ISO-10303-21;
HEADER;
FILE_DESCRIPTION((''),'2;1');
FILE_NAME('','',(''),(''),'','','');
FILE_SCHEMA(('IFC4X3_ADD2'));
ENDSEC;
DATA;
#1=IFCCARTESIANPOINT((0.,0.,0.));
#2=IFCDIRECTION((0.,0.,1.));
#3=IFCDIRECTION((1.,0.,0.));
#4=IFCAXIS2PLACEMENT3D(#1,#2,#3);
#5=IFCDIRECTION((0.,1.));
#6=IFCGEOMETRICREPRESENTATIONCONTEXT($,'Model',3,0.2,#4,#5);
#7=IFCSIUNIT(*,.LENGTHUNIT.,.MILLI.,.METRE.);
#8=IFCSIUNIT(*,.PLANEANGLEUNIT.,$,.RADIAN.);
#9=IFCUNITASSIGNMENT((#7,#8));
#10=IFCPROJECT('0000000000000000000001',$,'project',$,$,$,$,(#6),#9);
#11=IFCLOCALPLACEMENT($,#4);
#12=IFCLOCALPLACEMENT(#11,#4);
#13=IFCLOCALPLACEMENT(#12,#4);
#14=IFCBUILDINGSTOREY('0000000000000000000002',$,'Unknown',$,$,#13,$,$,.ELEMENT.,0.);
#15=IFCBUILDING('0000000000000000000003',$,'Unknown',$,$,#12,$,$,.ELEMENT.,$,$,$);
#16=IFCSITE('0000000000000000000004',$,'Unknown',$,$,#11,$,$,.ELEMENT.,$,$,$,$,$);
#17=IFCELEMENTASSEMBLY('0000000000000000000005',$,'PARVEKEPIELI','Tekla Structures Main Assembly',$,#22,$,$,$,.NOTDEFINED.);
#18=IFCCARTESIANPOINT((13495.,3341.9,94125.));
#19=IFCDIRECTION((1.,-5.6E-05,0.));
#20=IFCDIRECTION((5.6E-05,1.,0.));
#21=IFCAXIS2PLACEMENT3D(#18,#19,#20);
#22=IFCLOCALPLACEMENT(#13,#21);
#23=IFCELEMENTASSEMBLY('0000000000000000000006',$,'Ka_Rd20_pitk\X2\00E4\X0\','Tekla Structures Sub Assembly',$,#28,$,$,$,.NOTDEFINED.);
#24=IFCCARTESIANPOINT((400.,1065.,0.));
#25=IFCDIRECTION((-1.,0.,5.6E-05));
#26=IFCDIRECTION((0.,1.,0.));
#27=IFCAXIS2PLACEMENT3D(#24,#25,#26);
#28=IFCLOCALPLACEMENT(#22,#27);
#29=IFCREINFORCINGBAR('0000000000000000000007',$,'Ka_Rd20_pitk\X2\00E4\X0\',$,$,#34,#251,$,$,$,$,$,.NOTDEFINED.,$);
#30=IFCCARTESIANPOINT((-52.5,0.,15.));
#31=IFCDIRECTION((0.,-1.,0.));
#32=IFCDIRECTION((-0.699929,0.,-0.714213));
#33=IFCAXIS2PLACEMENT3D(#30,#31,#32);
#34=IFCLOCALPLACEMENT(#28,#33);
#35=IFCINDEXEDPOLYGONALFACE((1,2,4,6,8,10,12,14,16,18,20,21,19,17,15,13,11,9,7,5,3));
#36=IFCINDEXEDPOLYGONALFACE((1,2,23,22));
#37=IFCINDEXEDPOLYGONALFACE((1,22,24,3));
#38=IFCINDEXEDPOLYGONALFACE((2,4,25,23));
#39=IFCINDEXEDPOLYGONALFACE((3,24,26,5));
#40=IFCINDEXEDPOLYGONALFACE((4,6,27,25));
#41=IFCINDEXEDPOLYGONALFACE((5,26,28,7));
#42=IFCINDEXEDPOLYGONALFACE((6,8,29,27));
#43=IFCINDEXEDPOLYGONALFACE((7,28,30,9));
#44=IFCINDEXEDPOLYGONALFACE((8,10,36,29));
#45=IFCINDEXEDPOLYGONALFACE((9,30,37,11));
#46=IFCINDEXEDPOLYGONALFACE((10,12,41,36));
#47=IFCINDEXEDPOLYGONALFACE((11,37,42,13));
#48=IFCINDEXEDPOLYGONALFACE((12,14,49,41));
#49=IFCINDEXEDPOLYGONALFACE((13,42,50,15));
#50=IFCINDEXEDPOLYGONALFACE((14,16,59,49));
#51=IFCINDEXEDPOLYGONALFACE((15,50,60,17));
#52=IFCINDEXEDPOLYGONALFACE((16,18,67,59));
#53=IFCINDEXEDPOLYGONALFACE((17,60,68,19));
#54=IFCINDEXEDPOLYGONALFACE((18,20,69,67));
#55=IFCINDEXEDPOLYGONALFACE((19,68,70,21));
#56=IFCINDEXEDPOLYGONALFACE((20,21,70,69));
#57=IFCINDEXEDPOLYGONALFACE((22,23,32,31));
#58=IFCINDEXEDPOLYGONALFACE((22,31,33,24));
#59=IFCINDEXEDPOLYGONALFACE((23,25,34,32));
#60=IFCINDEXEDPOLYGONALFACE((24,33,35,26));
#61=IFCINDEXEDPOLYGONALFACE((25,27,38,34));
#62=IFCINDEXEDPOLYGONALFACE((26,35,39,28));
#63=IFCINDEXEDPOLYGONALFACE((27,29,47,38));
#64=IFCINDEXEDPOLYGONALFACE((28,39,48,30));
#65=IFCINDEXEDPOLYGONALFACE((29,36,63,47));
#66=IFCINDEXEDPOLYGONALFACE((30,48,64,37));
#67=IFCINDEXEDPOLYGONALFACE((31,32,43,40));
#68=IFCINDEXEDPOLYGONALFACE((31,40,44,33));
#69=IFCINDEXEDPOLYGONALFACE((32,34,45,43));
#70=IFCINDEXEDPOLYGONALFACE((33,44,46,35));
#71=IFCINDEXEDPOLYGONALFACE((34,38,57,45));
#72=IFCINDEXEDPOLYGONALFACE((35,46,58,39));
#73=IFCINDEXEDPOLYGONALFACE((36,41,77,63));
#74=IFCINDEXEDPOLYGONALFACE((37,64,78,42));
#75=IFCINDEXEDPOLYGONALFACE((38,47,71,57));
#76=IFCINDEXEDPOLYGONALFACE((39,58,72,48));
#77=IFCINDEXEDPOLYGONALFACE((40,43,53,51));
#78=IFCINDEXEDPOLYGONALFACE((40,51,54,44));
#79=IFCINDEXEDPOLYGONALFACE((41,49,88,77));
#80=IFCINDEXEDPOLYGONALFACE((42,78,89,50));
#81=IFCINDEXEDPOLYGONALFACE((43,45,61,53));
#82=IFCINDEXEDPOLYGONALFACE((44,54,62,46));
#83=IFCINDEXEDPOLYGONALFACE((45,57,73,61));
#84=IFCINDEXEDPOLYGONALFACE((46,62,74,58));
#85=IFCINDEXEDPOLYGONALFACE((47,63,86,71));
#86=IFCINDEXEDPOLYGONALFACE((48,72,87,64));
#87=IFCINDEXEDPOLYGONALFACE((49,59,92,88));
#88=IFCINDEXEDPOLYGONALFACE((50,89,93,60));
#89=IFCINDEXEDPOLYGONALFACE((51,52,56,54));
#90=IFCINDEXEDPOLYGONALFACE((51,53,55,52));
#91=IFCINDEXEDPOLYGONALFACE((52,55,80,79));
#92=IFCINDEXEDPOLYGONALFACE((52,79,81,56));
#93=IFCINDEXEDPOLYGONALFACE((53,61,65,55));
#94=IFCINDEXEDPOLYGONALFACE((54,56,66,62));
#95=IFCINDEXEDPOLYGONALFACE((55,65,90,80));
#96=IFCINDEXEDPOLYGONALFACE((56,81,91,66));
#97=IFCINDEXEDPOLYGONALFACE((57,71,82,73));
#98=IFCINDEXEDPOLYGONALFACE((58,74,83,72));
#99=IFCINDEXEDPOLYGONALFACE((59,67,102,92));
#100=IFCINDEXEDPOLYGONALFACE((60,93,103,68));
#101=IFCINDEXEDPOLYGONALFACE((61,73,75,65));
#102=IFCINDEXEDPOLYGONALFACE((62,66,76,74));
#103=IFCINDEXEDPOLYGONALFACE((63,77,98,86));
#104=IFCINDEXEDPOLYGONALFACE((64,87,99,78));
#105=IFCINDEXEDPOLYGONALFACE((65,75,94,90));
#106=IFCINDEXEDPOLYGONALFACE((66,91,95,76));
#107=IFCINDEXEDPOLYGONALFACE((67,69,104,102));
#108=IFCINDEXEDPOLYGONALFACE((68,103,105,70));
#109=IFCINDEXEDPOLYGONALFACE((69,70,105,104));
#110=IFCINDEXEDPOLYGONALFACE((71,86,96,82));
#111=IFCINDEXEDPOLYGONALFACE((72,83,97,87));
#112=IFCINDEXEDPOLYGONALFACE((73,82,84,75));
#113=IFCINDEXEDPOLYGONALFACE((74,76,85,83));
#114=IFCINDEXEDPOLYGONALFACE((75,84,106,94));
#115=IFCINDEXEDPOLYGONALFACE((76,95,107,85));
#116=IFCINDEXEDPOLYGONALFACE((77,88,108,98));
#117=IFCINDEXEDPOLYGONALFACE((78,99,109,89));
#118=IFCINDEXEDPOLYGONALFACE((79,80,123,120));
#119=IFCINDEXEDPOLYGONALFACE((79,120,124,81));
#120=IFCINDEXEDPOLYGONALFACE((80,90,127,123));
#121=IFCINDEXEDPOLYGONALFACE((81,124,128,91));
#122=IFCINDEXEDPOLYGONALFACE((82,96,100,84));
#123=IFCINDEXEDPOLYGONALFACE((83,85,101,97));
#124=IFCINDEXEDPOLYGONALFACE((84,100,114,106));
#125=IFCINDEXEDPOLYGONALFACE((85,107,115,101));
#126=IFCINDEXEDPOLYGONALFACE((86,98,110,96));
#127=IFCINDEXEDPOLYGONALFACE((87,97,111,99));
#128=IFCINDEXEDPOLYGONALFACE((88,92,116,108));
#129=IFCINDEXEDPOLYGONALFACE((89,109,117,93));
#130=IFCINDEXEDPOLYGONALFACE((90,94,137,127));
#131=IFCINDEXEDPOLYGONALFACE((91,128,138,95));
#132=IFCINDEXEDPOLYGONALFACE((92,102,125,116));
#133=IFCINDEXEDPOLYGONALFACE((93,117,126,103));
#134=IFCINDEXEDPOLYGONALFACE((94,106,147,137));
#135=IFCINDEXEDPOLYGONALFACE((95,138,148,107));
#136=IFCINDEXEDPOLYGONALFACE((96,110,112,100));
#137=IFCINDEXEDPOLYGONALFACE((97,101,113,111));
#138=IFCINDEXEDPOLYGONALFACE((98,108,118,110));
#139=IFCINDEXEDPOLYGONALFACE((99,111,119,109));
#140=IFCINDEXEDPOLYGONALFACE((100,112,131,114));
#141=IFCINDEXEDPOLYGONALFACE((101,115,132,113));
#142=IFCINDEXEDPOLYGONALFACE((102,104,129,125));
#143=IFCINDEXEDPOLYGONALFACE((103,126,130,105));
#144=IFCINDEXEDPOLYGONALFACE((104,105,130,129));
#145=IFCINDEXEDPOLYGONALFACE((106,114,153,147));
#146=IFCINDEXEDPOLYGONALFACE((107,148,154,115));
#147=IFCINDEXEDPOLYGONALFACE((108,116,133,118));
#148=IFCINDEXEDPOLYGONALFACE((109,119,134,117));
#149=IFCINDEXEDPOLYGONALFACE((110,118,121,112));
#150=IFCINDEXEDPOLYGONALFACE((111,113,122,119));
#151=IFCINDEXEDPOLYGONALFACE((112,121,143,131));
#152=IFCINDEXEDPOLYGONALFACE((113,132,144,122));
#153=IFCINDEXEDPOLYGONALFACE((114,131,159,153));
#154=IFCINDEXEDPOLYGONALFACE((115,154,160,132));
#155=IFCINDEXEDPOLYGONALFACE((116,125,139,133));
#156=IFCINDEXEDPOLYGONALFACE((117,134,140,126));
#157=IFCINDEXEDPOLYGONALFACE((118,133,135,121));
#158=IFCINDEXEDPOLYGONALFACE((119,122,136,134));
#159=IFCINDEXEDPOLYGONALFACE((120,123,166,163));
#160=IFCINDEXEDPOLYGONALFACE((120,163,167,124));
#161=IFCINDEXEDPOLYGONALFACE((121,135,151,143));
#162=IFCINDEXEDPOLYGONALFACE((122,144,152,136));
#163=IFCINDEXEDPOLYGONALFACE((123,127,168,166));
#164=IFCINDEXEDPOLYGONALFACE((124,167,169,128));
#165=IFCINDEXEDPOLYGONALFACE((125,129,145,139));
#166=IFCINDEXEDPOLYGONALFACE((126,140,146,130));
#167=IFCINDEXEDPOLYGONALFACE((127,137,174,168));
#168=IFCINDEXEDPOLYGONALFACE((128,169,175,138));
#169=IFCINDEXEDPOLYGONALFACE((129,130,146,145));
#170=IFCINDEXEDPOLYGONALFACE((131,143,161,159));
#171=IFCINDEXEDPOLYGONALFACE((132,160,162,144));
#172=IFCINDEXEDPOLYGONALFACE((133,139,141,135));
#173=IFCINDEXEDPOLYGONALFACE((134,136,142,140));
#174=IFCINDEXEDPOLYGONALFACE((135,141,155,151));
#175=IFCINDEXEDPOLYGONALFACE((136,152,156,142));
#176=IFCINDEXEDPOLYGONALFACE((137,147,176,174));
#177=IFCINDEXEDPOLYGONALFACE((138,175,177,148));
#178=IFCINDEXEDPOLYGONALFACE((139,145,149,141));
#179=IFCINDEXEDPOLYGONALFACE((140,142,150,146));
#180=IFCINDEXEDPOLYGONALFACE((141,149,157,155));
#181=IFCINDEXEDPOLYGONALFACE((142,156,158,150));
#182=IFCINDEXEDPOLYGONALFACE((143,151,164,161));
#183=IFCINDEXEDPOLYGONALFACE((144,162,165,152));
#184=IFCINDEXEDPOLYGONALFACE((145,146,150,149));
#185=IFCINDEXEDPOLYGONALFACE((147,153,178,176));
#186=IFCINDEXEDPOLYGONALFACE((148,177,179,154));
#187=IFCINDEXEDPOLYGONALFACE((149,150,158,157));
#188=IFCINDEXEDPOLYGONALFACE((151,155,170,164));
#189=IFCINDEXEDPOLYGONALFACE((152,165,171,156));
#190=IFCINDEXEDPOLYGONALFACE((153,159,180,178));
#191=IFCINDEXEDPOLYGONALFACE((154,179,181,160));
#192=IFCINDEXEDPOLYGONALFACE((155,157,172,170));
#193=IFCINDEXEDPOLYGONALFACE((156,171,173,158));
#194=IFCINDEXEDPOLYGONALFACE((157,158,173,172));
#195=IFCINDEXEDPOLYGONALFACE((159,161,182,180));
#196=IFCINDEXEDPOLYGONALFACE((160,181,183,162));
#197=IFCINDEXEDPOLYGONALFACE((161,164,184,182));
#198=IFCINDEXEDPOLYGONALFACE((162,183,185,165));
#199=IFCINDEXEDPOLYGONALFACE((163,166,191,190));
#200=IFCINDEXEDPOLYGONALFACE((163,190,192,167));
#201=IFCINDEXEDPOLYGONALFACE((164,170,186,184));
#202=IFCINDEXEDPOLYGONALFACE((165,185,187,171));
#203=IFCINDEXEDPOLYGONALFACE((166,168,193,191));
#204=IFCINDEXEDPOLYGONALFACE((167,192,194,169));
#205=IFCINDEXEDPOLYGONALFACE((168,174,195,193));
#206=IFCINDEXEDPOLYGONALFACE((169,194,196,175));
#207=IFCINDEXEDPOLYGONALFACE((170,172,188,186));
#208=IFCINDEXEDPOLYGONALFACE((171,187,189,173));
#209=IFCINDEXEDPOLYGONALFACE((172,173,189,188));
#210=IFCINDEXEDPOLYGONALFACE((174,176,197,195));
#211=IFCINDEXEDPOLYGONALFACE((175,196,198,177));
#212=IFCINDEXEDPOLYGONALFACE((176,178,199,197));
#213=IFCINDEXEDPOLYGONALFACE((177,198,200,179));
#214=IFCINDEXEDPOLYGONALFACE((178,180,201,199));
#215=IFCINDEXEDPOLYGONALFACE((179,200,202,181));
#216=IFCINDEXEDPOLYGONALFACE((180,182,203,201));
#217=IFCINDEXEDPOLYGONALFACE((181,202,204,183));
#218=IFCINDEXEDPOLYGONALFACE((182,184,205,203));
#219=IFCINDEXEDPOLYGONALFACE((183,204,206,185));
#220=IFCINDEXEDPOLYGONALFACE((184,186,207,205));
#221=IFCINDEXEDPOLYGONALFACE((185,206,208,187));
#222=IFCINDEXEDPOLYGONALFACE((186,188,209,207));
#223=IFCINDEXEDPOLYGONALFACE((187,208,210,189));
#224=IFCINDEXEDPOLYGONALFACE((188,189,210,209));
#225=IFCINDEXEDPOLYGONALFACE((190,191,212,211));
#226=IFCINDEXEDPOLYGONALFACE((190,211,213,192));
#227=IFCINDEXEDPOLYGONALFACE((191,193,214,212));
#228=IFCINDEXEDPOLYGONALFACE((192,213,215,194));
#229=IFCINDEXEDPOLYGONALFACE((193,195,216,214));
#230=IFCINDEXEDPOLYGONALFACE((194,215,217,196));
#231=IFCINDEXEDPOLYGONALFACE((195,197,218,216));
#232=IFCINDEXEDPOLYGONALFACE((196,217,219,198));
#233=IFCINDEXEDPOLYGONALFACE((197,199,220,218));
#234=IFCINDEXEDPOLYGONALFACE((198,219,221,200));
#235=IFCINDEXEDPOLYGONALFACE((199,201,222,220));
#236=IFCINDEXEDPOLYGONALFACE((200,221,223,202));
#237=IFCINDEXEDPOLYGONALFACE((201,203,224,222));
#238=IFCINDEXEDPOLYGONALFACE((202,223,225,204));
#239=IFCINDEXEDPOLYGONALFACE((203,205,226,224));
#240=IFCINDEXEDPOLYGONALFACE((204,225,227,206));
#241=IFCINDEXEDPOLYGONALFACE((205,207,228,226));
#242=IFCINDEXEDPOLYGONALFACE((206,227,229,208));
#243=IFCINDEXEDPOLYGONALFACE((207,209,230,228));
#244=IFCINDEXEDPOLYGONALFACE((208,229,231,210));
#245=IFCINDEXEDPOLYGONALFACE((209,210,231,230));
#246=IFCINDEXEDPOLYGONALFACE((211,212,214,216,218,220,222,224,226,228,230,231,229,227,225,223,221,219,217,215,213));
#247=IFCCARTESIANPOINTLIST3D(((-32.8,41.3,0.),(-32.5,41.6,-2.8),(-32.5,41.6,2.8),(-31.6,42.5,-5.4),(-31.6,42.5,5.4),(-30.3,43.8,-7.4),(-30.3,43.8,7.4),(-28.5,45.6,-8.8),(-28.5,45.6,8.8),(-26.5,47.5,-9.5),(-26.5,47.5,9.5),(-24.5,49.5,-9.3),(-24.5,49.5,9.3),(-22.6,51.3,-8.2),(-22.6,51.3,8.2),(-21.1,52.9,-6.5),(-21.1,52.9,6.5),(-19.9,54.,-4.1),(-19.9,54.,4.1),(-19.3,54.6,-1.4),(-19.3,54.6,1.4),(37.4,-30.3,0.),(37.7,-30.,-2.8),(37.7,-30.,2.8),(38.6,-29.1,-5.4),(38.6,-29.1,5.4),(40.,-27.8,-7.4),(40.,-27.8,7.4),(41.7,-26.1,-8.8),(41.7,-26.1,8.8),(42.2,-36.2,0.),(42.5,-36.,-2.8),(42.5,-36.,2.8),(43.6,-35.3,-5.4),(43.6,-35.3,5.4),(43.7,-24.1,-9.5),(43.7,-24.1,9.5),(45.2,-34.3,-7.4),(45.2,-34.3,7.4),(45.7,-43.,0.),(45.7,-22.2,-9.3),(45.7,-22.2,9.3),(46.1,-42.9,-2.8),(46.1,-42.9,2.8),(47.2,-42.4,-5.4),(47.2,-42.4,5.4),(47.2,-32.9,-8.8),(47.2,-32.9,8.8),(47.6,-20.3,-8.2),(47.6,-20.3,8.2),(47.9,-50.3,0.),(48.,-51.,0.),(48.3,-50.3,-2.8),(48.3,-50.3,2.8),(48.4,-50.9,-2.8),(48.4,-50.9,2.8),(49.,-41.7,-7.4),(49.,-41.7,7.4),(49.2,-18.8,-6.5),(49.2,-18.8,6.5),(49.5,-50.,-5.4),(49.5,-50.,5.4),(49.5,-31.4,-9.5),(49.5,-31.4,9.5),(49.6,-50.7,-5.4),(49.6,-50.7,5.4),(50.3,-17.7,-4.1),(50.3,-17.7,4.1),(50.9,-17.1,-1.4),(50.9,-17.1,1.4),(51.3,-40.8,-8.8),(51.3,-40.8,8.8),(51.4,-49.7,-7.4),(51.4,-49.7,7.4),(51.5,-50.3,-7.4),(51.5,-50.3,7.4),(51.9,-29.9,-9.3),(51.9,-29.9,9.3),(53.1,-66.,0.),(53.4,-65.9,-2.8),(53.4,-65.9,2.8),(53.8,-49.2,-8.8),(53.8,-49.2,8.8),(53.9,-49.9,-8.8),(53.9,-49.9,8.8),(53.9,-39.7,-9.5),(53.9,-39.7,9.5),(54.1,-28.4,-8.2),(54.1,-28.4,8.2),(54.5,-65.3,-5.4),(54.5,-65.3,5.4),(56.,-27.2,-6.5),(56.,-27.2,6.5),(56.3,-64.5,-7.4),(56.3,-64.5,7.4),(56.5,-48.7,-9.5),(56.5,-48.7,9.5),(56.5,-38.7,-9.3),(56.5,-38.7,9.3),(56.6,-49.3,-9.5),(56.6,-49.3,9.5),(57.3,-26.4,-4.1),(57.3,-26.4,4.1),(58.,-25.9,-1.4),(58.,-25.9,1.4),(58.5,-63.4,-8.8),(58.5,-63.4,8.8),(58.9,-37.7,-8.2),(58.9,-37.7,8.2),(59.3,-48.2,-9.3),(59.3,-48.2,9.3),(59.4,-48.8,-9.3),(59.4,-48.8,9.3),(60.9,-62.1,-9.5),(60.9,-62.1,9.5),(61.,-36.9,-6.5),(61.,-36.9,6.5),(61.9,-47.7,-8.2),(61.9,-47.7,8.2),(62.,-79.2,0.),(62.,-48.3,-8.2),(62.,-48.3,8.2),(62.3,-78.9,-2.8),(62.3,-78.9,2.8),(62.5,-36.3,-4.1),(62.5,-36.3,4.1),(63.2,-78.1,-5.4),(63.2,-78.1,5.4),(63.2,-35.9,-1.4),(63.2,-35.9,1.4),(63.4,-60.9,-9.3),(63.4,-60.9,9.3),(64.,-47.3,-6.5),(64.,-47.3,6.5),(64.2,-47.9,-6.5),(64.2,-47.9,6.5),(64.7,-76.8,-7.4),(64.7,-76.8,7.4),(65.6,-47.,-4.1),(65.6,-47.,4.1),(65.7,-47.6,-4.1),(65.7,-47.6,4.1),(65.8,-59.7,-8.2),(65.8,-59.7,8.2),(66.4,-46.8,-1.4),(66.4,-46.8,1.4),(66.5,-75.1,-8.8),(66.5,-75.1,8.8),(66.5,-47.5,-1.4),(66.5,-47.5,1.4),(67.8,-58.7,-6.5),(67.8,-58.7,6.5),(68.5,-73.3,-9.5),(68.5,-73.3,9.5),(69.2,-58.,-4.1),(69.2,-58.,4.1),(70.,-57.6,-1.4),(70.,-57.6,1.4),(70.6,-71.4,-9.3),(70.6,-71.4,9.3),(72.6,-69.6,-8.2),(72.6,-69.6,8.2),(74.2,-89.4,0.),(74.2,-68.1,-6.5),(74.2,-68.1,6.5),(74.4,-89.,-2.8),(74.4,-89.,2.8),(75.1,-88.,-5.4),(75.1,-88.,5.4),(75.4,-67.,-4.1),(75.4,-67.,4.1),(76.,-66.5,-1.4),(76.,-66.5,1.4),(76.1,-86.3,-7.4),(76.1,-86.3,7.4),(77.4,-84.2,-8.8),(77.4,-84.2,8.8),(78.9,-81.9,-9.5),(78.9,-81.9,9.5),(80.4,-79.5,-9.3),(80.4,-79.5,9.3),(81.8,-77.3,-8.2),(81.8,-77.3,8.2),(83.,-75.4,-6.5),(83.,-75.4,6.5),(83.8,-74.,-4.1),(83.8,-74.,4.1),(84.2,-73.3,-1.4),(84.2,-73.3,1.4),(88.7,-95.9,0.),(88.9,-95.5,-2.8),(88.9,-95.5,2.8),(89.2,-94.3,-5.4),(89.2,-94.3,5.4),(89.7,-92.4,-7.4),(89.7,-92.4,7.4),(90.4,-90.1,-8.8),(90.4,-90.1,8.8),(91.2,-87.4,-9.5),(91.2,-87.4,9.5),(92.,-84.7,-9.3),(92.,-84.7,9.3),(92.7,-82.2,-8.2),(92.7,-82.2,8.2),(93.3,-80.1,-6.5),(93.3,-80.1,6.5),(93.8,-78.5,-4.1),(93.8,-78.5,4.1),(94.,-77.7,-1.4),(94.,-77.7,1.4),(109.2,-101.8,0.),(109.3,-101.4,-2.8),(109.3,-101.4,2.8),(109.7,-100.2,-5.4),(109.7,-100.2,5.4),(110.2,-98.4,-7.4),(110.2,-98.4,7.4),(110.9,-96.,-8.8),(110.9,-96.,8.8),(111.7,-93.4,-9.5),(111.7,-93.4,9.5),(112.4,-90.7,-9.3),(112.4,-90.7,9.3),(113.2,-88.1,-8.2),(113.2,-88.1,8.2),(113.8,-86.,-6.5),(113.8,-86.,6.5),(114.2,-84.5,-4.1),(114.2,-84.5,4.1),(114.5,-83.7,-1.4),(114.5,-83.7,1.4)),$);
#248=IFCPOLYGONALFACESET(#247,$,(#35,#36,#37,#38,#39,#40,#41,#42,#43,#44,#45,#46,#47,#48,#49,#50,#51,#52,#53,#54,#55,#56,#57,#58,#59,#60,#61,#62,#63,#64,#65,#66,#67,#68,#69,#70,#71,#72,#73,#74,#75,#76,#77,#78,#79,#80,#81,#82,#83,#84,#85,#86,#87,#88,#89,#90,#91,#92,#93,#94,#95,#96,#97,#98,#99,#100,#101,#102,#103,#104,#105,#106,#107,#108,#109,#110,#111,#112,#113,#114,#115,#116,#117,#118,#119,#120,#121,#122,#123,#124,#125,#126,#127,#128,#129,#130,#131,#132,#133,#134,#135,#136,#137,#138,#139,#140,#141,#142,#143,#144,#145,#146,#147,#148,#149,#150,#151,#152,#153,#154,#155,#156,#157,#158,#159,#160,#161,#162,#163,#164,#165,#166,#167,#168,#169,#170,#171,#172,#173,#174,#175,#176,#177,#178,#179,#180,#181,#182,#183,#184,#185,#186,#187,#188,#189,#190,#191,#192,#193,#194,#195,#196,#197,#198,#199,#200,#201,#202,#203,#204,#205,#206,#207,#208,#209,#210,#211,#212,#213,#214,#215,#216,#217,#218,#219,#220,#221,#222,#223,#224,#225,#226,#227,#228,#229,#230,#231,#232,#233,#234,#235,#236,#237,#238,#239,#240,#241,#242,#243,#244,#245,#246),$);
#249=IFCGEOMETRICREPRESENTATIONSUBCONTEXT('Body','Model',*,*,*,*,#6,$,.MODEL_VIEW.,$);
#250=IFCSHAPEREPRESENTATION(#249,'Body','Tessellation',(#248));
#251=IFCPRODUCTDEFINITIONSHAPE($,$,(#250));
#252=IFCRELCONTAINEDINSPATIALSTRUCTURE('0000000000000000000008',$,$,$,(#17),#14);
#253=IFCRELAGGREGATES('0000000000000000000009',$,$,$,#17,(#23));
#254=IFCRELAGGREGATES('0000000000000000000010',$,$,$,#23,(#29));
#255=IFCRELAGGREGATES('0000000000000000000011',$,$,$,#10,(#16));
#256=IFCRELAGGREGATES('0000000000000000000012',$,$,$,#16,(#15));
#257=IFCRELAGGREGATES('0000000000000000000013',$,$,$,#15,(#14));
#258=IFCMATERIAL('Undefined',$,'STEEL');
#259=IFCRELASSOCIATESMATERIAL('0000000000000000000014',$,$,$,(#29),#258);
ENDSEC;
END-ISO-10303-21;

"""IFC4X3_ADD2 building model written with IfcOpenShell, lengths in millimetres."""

from ifc_helpers import new_model, entity, si_unit, direction, frame, origin_with_axes, place, context, subcontext, project, spatial, material, element, aggregate, save


model = new_model("IFC4X3_ADD2")

# Units and contexts
model_context = context("Model", 3, precision=0.2, world=origin_with_axes(), true_north=direction((0.0, 1.0)))
body_context = subcontext(model_context, "Body", "Model", "MODEL_VIEW")
ifc_project = project(units=[si_unit("LENGTHUNIT", "METRE", prefix="MILLI"), si_unit("PLANEANGLEUNIT", "RADIAN")], contexts=[model_context])

# Site, building, storey
site_placement = place(None, origin_with_axes())
site = spatial("IfcSite", under=ifc_project, at=site_placement, Name="Unknown", CompositionType="ELEMENT")
building_placement = place(site_placement, origin_with_axes())
building = spatial("IfcBuilding", under=site, at=building_placement, Name="Unknown", CompositionType="ELEMENT")
storey_placement = place(building_placement, origin_with_axes())
storey = spatial("IfcBuildingStorey", under=building, at=storey_placement, Name="Unknown", CompositionType="ELEMENT", Elevation=0.0)

# Element assemblies
assembly_1_placement = place(storey_placement, frame((13495.0, 3341.9, 94125.0), z_axis=(1.0, -0.000056, 0.0), x_axis=(0.000056, 1.0, 0.0)))
assembly_1 = element("IfcElementAssembly", 1, at=assembly_1_placement, inside=storey, Name="PARVEKEPIELI", Description="Tekla Structures Main Assembly", PredefinedType="NOTDEFINED")
assembly_2_placement = place(assembly_1_placement, frame((400.0, 1065.0, 0.0), z_axis=(-1.0, 0.0, 0.000056), x_axis=(0.0, 1.0, 0.0)))
assembly_2 = element("IfcElementAssembly", 2, at=assembly_2_placement, Name="Ka_Rd20_pitkä", Description="Tekla Structures Sub Assembly", PredefinedType="NOTDEFINED")

aggregate(assembly_1, [assembly_2])

# Reinforcing bar
ifc_material_1 = material(Name="Undefined", Category="STEEL")
reinforcing_bar_1_placement = place(assembly_2_placement, frame((-52.5, 0.0, 15.0), z_axis=(0.0, -1.0, 0.0), x_axis=(-0.699929, 0.0, -0.714213)))
reinforcing_bar_1 = element("IfcReinforcingBar", 3, at=reinforcing_bar_1_placement, material=ifc_material_1, Name="Ka_Rd20_pitkä", PredefinedType="NOTDEFINED", context=body_context, shape_type="AdvancedSweptSolid", body=[
    entity("IfcSweptDiskSolid", entity("IfcIndexedPolyCurve", entity("IfcCartesianPointList3D", [[-26.0, 48.0, 0.0], [44.2, -23.7, 0.0], [52.5, -35.1, 0.0], [57.2, -48.6, 0.0], [57.3, -49.2, 0.0], [69.1, -72.8, 0.0], [91.4, -86.7, 0.0], [111.9, -92.7, 0.0]]), [entity("IfcLineIndex", [1, 2]), entity("IfcArcIndex", [2, 3, 4]), entity("IfcLineIndex", [4, 5]), entity("IfcArcIndex", [5, 6, 7]), entity("IfcLineIndex", [7, 8])]), 9.5),
])
aggregate(assembly_2, [reinforcing_bar_1])

save(model, "model.ifc")
